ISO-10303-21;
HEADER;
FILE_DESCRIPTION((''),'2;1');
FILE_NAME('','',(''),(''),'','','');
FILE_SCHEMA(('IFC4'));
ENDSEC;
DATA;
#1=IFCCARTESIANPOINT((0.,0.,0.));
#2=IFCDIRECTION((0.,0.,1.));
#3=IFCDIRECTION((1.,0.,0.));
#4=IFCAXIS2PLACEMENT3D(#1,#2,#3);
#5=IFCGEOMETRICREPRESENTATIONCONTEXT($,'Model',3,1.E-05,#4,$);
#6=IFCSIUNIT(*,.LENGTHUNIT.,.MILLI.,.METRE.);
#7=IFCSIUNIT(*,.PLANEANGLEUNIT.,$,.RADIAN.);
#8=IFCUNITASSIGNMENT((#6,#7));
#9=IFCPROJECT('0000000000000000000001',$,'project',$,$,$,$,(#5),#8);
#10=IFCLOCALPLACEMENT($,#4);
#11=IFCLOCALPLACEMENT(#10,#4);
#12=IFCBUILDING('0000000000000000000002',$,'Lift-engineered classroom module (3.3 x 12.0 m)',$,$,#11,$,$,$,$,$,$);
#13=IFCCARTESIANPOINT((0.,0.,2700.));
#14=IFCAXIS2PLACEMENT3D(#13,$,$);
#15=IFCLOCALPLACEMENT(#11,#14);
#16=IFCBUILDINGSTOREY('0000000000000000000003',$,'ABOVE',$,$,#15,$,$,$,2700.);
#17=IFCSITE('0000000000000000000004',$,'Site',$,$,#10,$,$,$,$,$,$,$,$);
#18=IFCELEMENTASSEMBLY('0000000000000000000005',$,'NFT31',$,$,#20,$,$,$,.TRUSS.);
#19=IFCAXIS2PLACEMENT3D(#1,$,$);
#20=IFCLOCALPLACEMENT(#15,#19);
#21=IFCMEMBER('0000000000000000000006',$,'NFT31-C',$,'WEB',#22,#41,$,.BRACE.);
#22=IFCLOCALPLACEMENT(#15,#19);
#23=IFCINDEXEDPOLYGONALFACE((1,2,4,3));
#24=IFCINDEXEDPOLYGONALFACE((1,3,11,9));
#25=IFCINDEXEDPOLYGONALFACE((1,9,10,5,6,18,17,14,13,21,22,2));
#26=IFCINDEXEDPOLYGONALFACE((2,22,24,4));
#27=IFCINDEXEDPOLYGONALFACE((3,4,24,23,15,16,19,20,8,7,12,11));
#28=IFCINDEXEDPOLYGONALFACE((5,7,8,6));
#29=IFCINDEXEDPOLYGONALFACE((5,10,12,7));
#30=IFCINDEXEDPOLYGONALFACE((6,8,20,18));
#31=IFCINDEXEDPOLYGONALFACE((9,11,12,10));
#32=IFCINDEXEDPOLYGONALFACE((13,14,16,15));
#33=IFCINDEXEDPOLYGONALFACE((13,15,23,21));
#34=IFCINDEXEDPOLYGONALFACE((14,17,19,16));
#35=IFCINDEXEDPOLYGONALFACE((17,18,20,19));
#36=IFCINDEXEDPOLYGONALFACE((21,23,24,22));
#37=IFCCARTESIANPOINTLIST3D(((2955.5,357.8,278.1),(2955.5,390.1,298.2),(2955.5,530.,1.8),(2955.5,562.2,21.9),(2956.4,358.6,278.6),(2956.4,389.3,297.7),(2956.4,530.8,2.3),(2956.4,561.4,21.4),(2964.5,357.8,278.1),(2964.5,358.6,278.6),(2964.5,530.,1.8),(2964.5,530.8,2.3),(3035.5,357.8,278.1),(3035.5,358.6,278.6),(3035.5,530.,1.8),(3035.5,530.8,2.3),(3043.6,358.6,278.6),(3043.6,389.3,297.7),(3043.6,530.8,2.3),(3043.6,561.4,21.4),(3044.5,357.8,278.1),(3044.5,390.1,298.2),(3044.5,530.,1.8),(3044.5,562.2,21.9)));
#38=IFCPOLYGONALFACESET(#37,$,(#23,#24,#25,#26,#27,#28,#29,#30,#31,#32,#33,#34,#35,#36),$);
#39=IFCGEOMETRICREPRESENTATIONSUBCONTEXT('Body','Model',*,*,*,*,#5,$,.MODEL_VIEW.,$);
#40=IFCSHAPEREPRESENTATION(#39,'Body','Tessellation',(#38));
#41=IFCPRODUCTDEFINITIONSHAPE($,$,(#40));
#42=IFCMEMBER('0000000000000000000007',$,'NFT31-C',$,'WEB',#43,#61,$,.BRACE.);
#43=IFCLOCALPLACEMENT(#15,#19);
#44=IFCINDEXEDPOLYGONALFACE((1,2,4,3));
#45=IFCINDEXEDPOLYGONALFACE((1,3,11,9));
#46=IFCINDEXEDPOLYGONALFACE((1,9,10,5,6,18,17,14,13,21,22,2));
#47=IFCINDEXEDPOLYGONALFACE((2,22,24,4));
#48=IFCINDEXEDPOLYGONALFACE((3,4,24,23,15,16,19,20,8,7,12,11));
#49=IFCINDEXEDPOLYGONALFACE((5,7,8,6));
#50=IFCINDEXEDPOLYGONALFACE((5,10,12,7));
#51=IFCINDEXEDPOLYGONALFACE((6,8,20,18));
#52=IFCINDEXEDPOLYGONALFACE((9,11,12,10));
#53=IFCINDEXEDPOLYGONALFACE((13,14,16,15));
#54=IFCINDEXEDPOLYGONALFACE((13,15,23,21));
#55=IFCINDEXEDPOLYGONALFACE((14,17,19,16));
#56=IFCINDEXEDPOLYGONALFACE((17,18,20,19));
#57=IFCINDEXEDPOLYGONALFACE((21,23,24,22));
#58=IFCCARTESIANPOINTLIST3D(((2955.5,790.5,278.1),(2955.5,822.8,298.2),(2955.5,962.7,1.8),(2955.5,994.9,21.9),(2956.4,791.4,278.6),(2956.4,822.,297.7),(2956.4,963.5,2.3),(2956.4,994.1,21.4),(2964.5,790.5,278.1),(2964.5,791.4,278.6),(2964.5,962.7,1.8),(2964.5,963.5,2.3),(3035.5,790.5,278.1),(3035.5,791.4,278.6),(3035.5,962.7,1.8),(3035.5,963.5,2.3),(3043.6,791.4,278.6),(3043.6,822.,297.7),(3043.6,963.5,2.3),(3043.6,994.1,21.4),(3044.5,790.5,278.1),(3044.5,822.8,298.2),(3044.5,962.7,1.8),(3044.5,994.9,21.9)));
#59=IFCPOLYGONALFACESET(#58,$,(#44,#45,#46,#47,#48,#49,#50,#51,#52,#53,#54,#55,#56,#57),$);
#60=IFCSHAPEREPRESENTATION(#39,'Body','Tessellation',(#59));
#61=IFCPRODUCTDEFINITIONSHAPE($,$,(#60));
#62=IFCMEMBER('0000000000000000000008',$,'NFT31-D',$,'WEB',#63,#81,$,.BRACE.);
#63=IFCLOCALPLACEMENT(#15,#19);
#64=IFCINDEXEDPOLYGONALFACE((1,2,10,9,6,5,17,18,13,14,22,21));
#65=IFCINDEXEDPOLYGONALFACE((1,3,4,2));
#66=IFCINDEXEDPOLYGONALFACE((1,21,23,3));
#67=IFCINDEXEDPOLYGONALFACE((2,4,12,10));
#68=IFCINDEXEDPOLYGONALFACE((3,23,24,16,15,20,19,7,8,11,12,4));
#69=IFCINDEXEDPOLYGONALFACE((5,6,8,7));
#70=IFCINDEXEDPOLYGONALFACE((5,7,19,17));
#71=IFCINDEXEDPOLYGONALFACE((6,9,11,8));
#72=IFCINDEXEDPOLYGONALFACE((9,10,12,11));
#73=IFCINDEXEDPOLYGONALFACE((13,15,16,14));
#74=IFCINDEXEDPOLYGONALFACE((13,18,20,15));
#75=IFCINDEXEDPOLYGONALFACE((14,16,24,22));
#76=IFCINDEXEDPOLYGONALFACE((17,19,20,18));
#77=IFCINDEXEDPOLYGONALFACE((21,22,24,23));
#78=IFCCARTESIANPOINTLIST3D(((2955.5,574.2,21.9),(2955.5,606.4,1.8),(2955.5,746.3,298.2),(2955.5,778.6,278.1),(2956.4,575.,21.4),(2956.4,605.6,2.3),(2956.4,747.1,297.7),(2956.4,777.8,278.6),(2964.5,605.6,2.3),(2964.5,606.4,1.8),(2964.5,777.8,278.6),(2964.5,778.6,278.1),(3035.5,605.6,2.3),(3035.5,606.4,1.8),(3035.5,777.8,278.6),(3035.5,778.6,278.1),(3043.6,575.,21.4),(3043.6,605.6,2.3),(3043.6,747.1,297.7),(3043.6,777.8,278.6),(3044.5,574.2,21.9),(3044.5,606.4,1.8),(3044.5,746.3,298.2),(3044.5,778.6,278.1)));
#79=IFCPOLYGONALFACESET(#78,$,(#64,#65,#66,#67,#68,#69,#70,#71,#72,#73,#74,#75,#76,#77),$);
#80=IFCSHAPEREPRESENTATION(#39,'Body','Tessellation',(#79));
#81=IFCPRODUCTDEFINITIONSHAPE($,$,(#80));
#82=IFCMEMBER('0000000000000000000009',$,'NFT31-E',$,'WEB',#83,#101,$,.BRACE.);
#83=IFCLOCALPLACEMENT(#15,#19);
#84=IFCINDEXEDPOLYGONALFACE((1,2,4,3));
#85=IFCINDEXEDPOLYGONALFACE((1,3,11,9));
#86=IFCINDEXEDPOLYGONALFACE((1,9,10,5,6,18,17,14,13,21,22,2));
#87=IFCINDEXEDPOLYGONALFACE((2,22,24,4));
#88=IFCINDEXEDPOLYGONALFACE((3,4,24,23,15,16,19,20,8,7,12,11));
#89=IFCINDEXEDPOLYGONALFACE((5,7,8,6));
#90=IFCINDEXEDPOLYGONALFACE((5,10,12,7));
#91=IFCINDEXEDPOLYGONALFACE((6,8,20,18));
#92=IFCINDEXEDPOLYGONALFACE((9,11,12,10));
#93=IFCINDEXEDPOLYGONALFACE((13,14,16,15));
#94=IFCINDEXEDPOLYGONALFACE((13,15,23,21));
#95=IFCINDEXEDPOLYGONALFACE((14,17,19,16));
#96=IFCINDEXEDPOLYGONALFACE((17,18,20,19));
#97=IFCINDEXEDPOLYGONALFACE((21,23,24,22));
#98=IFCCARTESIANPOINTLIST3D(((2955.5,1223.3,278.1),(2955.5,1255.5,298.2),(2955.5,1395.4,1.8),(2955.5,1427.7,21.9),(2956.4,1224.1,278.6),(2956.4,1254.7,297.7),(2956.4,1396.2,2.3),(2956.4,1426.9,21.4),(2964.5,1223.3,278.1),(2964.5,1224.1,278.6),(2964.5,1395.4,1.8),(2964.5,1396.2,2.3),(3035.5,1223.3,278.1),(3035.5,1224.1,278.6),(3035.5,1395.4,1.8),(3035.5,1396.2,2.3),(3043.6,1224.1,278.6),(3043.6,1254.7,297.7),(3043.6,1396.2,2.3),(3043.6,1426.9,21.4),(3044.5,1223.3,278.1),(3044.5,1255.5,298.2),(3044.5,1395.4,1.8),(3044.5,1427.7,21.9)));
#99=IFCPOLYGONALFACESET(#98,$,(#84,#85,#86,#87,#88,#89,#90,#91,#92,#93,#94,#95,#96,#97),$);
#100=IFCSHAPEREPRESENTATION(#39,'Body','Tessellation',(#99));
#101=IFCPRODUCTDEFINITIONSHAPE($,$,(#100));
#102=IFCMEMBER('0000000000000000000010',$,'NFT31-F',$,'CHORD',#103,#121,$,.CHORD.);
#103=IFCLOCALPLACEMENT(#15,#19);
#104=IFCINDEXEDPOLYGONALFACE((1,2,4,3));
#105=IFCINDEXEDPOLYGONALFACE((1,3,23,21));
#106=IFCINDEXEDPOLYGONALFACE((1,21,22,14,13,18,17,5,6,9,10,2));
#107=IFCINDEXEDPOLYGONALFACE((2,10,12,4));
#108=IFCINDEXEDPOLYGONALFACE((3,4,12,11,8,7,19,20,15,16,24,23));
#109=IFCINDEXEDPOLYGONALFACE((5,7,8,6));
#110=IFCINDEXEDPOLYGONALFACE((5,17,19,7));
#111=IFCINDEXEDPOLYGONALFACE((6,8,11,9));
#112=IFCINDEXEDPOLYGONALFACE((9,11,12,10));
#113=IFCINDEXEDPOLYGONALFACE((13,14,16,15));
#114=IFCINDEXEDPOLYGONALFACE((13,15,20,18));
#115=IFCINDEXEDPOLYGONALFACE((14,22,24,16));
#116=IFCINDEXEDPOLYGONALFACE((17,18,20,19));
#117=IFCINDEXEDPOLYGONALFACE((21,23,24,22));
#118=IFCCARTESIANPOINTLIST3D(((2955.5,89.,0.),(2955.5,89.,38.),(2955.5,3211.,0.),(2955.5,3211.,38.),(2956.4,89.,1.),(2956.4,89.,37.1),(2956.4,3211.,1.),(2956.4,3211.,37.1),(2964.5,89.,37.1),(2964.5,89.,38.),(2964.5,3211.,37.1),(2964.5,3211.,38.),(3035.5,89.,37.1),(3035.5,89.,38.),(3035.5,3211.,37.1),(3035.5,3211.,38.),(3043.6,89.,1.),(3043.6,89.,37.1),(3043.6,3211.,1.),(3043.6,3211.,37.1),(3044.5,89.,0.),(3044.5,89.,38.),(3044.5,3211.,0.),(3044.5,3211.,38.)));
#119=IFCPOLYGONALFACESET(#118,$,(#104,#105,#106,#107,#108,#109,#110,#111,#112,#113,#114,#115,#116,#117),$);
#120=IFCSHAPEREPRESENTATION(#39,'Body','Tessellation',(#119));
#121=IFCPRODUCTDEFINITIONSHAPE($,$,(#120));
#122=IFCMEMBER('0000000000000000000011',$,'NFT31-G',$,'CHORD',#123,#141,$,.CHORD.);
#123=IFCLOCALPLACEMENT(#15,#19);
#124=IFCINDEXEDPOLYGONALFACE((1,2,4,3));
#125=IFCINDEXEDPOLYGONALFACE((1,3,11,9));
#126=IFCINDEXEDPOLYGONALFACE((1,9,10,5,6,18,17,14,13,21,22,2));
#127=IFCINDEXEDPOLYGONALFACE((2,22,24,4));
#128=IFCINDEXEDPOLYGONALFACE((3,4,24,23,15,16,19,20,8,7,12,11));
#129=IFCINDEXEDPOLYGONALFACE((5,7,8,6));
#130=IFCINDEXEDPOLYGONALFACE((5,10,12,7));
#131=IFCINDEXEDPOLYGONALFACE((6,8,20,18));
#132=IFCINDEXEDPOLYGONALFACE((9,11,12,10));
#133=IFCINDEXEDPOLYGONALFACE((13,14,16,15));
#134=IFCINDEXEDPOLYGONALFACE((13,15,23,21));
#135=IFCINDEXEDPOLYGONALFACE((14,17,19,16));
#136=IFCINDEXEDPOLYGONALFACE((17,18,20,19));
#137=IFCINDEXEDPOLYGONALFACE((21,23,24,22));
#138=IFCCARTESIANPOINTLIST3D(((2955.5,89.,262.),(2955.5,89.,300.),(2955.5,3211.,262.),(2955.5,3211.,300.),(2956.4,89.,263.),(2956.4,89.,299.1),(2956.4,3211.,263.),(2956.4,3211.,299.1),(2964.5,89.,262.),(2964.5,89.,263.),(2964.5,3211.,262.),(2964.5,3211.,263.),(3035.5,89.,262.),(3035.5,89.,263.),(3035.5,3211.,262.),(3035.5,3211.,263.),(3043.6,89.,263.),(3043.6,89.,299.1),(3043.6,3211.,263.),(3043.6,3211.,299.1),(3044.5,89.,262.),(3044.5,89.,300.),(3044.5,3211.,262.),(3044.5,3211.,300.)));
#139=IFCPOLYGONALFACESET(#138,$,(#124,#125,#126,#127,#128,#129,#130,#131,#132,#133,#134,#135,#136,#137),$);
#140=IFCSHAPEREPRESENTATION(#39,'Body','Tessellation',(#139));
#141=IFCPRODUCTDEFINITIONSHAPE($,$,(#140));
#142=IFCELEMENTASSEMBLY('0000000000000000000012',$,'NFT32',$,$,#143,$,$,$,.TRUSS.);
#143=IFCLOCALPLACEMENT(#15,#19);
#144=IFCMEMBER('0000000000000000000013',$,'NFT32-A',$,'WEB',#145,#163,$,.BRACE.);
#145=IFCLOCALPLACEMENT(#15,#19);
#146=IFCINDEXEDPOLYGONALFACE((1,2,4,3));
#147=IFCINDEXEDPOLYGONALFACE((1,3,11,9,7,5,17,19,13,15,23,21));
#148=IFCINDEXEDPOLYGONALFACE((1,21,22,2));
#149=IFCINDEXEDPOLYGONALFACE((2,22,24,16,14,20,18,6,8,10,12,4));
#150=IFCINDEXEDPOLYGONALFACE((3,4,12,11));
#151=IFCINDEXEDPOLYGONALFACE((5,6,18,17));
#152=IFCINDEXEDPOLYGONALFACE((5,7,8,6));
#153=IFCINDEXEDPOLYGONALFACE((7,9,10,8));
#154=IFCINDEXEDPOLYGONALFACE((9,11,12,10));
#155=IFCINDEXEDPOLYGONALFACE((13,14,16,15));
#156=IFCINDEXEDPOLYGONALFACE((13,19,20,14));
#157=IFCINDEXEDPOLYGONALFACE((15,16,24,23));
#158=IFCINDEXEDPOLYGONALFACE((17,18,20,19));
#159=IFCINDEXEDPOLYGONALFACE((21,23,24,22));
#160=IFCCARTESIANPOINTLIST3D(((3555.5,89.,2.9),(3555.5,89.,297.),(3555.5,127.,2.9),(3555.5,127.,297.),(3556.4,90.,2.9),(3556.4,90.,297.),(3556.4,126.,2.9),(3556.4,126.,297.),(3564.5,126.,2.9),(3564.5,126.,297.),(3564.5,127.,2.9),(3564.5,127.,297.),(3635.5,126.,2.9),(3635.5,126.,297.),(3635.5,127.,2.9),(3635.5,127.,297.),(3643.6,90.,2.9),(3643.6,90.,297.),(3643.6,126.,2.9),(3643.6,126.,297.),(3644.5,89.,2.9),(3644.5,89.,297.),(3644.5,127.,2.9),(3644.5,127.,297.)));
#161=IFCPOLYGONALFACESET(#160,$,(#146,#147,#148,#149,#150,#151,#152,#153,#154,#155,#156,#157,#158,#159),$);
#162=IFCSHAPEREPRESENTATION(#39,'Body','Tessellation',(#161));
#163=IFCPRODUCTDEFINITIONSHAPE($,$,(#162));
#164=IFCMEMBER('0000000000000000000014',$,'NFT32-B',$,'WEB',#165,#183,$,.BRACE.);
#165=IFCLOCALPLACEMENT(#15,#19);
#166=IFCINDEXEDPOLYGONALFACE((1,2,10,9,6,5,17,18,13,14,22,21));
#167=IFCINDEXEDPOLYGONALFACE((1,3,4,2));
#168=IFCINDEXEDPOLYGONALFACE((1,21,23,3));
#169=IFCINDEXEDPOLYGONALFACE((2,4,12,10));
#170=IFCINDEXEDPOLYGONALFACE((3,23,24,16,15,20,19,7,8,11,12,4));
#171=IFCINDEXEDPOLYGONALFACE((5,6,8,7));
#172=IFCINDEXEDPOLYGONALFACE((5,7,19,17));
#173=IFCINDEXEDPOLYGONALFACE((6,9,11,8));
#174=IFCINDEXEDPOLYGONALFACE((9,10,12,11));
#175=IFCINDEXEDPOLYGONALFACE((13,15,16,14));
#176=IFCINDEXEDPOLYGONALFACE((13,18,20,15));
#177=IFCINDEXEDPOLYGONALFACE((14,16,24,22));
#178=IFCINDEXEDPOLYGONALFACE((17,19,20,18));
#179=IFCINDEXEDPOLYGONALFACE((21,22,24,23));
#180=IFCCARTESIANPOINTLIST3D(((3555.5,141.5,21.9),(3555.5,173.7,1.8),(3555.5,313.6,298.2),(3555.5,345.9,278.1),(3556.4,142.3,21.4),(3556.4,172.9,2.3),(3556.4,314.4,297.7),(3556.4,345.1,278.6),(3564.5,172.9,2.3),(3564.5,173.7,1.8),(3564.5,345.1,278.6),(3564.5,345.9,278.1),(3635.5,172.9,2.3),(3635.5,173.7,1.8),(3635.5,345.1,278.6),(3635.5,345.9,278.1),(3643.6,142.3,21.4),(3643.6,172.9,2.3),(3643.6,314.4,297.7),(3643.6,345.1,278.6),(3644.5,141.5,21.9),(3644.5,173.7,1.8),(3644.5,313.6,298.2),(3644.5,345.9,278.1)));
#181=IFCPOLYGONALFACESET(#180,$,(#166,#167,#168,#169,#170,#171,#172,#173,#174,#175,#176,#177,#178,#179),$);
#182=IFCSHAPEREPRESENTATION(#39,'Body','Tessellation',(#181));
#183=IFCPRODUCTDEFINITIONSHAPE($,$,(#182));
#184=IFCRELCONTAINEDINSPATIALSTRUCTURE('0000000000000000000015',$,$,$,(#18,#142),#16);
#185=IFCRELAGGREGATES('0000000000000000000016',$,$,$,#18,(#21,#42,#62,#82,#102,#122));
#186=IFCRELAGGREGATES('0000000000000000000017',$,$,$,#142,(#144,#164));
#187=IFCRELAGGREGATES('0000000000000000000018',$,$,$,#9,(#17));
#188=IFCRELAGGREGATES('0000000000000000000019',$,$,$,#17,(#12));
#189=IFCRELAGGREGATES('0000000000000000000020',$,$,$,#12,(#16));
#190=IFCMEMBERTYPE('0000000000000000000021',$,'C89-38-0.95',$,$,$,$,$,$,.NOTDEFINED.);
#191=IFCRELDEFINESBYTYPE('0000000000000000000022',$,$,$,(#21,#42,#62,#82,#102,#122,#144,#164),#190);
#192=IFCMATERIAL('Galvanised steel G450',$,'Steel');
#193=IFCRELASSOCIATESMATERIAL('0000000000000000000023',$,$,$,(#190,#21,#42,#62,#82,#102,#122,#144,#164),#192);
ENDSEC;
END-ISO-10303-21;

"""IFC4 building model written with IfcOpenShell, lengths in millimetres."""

from ifc_helpers import new_model, si_unit, frame, origin, origin_with_axes, origin_2d, place, context, subcontext, project, spatial, c_section, extrude, material, material_profile, profile_set, profile_usage, type_object, element, aggregate, save


model = new_model("IFC4")

# Units and contexts
model_context = context("Model", 3, precision=1e-05, world=origin_with_axes())
body_context = subcontext(model_context, "Body", "Model", "MODEL_VIEW")
ifc_project = project(units=[si_unit("LENGTHUNIT", "METRE", prefix="MILLI"), si_unit("PLANEANGLEUNIT", "RADIAN")], contexts=[model_context])

# Site, building, storey
site_placement = place(None, origin_with_axes())
site = spatial("IfcSite", under=ifc_project, at=site_placement, Name="Site")
building_placement = place(site_placement, origin_with_axes())
building = spatial("IfcBuilding", under=site, at=building_placement, Name="Lift-engineered classroom module (3.3 x 12.0 m)")
storey_placement = place(building_placement, frame((0.0, 0.0, 2700.0)))
storey = spatial("IfcBuildingStorey", under=building, at=storey_placement, Name="ABOVE", Elevation=2700.0)

# Element assemblies, members
ifc_material = material(Name="Galvanised steel G450", Category="Steel")
ifc_material_profile = material_profile(ifc_material, c_section(Depth=89.0, Width=38.0, WallThickness=0.9, Girth=9.0, at=origin_2d()), Name="C89-38-0.95")
ifc_profile_set = profile_set([ifc_material_profile], Name="C89-38-0.95")
ifc_profile_usage = profile_usage(ifc_profile_set)
member_type = type_object("IfcMemberType", Name="C89-38-0.95", PredefinedType="NOTDEFINED", material=ifc_profile_set)
assembly_1_placement = place(storey_placement, frame((3000.0, 89.0, 0.0)))
assembly_1 = element("IfcElementAssembly", 1, at=assembly_1_placement, inside=storey, Name="NFT31", PredefinedType="TRUSS")
member_1_placement = place(assembly_1_placement, frame((0.0, 457.1, 11.8), z_axis=(0.0, -0.528797, 0.848748), x_axis=(0.0, -0.848748, -0.528797)))
member_1 = element("IfcMember", 2, at=member_1_placement, type_object=member_type, material=ifc_profile_usage, Name="NFT31-C", ObjectType="WEB", PredefinedType="BRACE", context=body_context, shape_type="SweptSolid", body=[
    extrude(c_section(Depth=89.0, Width=38.0, WallThickness=0.9, Girth=9.0, at=origin_2d()), origin(), (0.0, 0.0, 1.0), 325.6),
])
member_2_placement = place(assembly_1_placement, frame((0.0, 889.8, 11.8), z_axis=(0.0, -0.528797, 0.848748), x_axis=(0.0, -0.848748, -0.528797)))
member_2 = element("IfcMember", 3, at=member_2_placement, type_object=member_type, material=ifc_profile_usage, Name="NFT31-C", ObjectType="WEB", PredefinedType="BRACE", context=body_context, shape_type="SweptSolid", body=[
    extrude(c_section(Depth=89.0, Width=38.0, WallThickness=0.9, Girth=9.0, at=origin_2d()), origin(), (0.0, 0.0, 1.0), 325.6),
])
member_3_placement = place(assembly_1_placement, frame((0.0, 501.3, 11.8), z_axis=(0.0, 0.528775, 0.848762), x_axis=(0.0, 0.848762, -0.528775)))
member_3 = element("IfcMember", 4, at=member_3_placement, type_object=member_type, material=ifc_profile_usage, Name="NFT31-D", ObjectType="WEB", PredefinedType="BRACE", context=body_context, shape_type="SweptSolid", body=[
    extrude(c_section(Depth=89.0, Width=38.0, WallThickness=0.9, Girth=9.0, at=origin_2d()), origin(), (0.0, 0.0, 1.0), 325.6),
])
member_4_placement = place(assembly_1_placement, frame((0.0, 1322.5, 11.8), z_axis=(0.0, -0.528775, 0.848762), x_axis=(0.0, -0.848762, -0.528775)))
member_4 = element("IfcMember", 5, at=member_4_placement, type_object=member_type, material=ifc_profile_usage, Name="NFT31-E", ObjectType="WEB", PredefinedType="BRACE", context=body_context, shape_type="SweptSolid", body=[
    extrude(c_section(Depth=89.0, Width=38.0, WallThickness=0.9, Girth=9.0, at=origin_2d()), origin(), (0.0, 0.0, 1.0), 325.6),
])
member_5_placement = place(assembly_1_placement, frame((0.0, 0.0, 19.0), z_axis=(0.0, 1.0, 0.0), x_axis=(0.0, 0.0, 1.0)))
member_5 = element("IfcMember", 6, at=member_5_placement, type_object=member_type, material=ifc_profile_usage, Name="NFT31-F", ObjectType="CHORD", PredefinedType="CHORD", context=body_context, shape_type="SweptSolid", body=[
    extrude(c_section(Depth=89.0, Width=38.0, WallThickness=0.9, Girth=9.0, at=origin_2d()), origin(), (0.0, 0.0, 1.0), 3122.0),
])
member_6_placement = place(assembly_1_placement, frame((0.0, 0.0, 281.0), z_axis=(0.0, 1.0, 0.0), x_axis=(0.0, 0.0, -1.0)))
member_6 = element("IfcMember", 7, at=member_6_placement, type_object=member_type, material=ifc_profile_usage, Name="NFT31-G", ObjectType="CHORD", PredefinedType="CHORD", context=body_context, shape_type="SweptSolid", body=[
    extrude(c_section(Depth=89.0, Width=38.0, WallThickness=0.9, Girth=9.0, at=origin_2d()), origin(), (0.0, 0.0, 1.0), 3122.0),
])
aggregate(assembly_1, [member_1, member_2, member_3, member_4, member_5, member_6])
assembly_2_placement = place(storey_placement, frame((3600.0, 89.0, 0.0)))
assembly_2 = element("IfcElementAssembly", 8, at=assembly_2_placement, inside=storey, Name="NFT32", PredefinedType="TRUSS")
member_7_placement = place(assembly_2_placement, frame((0.0, 19.0, 2.9), z_axis=(0.0, 0.0, 1.0), x_axis=(0.0, 1.0, 0.0)))
member_7 = element("IfcMember", 9, at=member_7_placement, type_object=member_type, material=ifc_profile_usage, Name="NFT32-A", ObjectType="WEB", PredefinedType="BRACE", context=body_context, shape_type="SweptSolid", body=[
    extrude(c_section(Depth=89.0, Width=38.0, WallThickness=0.9, Girth=9.0, at=origin_2d()), origin(), (0.0, 0.0, 1.0), 294.1),
])
member_8_placement = place(assembly_2_placement, frame((0.0, 68.6, 11.8), z_axis=(0.0, 0.528797, 0.848748), x_axis=(0.0, 0.848748, -0.528797)))
member_8 = element("IfcMember", 10, at=member_8_placement, type_object=member_type, material=ifc_profile_usage, Name="NFT32-B", ObjectType="WEB", PredefinedType="BRACE", context=body_context, shape_type="SweptSolid", body=[
    extrude(c_section(Depth=89.0, Width=38.0, WallThickness=0.9, Girth=9.0, at=origin_2d()), origin(), (0.0, 0.0, 1.0), 325.6),
])
aggregate(assembly_2, [member_7, member_8])

save(model, "model.ifc")
